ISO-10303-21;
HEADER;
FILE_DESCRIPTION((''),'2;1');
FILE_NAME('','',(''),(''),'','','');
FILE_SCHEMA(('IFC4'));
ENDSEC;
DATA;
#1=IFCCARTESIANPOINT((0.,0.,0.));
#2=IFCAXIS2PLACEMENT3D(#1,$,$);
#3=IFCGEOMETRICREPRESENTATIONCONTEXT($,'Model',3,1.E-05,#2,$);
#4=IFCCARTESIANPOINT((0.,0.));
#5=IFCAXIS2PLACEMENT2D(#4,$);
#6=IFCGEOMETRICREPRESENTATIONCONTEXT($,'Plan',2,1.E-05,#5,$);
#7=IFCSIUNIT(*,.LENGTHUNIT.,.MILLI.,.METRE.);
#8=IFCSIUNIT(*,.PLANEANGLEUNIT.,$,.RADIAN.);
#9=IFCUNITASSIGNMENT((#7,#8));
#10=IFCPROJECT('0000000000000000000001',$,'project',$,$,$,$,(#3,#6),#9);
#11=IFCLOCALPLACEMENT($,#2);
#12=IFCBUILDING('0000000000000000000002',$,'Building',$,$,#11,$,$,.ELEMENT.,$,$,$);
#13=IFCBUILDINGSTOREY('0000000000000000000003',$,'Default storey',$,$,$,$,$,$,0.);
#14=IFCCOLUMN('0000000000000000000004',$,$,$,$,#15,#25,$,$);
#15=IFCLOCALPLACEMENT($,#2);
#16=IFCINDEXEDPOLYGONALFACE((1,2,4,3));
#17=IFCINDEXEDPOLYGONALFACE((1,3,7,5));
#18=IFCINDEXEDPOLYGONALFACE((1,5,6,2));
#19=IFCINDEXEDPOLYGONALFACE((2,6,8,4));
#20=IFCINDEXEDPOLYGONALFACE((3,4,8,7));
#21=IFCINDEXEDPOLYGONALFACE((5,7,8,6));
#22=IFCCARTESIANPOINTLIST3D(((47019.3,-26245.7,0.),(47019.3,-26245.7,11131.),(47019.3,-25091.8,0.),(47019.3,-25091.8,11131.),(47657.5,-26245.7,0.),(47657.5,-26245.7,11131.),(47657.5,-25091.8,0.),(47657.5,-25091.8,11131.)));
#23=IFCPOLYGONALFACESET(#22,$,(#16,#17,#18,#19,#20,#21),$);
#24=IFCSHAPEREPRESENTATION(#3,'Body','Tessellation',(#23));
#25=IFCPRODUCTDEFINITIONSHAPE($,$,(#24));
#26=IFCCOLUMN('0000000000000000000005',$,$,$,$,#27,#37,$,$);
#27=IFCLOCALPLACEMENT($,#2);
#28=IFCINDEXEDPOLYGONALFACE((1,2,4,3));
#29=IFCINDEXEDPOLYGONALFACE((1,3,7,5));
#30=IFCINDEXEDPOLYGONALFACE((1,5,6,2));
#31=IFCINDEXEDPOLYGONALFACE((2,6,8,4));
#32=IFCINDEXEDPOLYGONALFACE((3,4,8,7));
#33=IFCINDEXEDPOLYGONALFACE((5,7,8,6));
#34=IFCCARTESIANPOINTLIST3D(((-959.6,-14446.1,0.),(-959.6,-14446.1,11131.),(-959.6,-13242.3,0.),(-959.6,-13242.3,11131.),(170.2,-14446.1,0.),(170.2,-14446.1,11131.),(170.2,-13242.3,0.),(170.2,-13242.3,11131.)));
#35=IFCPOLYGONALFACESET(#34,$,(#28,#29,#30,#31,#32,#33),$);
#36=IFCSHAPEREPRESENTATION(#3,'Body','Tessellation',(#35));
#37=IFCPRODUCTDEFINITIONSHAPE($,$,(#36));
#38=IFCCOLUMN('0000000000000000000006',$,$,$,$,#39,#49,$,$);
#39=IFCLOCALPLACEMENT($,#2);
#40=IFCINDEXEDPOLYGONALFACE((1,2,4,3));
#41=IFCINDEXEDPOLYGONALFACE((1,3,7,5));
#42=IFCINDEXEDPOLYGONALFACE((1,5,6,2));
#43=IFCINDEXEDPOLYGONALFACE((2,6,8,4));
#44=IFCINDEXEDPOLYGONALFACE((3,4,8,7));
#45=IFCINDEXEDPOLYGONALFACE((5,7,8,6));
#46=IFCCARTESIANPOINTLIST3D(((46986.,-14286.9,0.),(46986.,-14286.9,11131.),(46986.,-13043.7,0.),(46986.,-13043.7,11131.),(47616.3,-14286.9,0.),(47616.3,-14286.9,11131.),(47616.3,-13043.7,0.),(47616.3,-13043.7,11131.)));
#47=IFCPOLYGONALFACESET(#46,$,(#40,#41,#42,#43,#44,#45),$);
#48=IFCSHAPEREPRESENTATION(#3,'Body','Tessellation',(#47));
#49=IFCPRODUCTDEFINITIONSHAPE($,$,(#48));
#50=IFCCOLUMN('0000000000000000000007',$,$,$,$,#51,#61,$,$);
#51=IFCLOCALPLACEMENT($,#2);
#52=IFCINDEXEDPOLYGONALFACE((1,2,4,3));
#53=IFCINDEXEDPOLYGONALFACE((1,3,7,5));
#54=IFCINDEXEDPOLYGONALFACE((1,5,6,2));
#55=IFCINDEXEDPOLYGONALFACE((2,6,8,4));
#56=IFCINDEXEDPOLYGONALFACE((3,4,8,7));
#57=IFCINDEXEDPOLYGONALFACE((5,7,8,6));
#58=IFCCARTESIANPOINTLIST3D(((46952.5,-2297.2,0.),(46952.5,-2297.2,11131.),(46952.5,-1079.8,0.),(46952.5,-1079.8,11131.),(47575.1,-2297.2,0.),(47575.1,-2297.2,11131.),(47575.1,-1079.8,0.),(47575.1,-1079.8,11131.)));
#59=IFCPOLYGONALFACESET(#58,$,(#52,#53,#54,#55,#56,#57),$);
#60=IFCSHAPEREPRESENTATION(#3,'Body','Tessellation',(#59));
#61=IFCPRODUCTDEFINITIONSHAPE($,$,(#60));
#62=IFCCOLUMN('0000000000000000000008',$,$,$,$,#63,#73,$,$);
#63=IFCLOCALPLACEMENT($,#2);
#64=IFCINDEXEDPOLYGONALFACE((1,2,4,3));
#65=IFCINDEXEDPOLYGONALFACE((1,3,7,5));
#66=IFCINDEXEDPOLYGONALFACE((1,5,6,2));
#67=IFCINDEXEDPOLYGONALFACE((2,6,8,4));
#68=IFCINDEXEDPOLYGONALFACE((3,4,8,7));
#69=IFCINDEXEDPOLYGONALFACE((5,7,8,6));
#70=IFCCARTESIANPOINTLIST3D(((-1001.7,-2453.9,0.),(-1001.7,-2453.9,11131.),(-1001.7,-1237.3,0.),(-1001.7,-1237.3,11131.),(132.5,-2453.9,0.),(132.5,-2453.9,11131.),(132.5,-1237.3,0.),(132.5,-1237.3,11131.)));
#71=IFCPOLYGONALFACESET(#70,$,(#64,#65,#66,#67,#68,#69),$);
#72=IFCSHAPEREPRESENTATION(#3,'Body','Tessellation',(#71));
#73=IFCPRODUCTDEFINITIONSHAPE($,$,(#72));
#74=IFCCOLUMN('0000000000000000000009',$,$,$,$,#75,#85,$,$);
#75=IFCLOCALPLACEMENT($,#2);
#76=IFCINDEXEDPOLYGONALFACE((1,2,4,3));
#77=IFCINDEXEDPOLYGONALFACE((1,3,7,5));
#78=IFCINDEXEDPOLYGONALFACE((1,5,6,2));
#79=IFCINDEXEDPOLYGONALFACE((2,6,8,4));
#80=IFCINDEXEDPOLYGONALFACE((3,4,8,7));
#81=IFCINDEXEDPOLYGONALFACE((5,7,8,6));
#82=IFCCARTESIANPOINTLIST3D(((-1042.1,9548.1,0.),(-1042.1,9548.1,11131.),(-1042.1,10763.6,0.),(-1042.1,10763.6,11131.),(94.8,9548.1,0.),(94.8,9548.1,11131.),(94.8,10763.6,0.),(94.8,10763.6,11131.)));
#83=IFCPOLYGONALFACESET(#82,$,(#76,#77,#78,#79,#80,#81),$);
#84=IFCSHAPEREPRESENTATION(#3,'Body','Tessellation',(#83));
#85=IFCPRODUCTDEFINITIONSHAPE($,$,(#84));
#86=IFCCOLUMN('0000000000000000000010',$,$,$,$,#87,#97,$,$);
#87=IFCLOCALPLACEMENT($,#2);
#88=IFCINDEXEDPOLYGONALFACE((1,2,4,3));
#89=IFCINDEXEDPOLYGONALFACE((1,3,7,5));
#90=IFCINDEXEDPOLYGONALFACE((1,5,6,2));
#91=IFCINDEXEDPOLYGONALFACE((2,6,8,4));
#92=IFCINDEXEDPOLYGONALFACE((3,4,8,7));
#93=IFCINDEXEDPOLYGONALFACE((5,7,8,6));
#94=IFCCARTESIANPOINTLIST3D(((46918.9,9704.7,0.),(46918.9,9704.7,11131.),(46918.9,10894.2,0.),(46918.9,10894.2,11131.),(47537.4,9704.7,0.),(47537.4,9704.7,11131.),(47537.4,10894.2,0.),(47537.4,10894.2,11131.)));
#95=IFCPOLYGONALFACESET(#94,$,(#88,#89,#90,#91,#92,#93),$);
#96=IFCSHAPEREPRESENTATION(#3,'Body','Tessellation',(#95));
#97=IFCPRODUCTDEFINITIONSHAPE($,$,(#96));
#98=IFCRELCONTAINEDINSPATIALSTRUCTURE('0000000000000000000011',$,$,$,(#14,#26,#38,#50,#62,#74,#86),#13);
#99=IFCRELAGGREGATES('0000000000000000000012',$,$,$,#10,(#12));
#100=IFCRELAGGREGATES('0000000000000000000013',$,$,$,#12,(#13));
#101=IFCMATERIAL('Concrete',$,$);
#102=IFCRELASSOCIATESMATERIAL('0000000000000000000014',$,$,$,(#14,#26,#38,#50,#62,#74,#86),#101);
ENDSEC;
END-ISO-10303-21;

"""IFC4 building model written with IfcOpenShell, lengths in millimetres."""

from ifc_helpers import new_model, si_unit, frame, origin, origin_2d, place, context, project, spatial, rectangle, extrude, material, element, save


model = new_model("IFC4")

# Units and contexts
model_context = context("Model", 3, precision=1e-05, world=origin())
plan_context = context("Plan", 2, precision=1e-05, world=origin_2d())
ifc_project = project(units=[si_unit("LENGTHUNIT", "METRE", prefix="MILLI"), si_unit("PLANEANGLEUNIT", "RADIAN")], contexts=[model_context, plan_context])

# Building, storey
placement = place(None, origin())
building = spatial("IfcBuilding", under=ifc_project, at=placement, Name="Building", CompositionType="ELEMENT")
storey = spatial("IfcBuildingStorey", under=building, Name="Default storey", Elevation=0.0)

# Columns
ifc_material_1 = material(Name="Concrete")
element("IfcColumn", 1, at=placement, inside=storey, material=ifc_material_1, context=model_context, shape_type="SweptSolid", body=[
    extrude(rectangle(XDim=638.2, YDim=1153.9, at=origin_2d()), frame((47338.4, -25668.8, 0.0), z_axis=(0.0, 0.0, 1.0), x_axis=(1000.0, 0.0, 0.0)), (0.0, 0.0, 1.0), 11131.0),
])
element("IfcColumn", 2, at=placement, inside=storey, material=ifc_material_1, context=model_context, shape_type="SweptSolid", body=[
    extrude(rectangle(XDim=1129.8, YDim=1203.8, at=origin_2d()), frame((-394.7, -13844.2, 0.0), z_axis=(0.0, 0.0, 1.0), x_axis=(1000.0, 0.0, 0.0)), (0.0, 0.0, 1.0), 11131.0),
])
element("IfcColumn", 3, at=placement, inside=storey, material=ifc_material_1, context=model_context, shape_type="SweptSolid", body=[
    extrude(rectangle(XDim=630.3, YDim=1243.2, at=origin_2d()), frame((47301.2, -13665.3, 0.0), z_axis=(0.0, 0.0, 1.0), x_axis=(1000.0, 0.0, 0.0)), (0.0, 0.0, 1.0), 11131.0),
])
element("IfcColumn", 4, at=placement, inside=storey, material=ifc_material_1, context=model_context, shape_type="SweptSolid", body=[
    extrude(rectangle(XDim=622.6, YDim=1217.4, at=origin_2d()), frame((47263.8, -1688.5, 0.0), z_axis=(0.0, 0.0, 1.0), x_axis=(1000.0, 0.0, 0.0)), (0.0, 0.0, 1.0), 11131.0),
])
element("IfcColumn", 5, at=placement, inside=storey, material=ifc_material_1, context=model_context, shape_type="SweptSolid", body=[
    extrude(rectangle(XDim=1134.2, YDim=1216.6, at=origin_2d()), frame((-434.6, -1845.6, 0.0), z_axis=(0.0, 0.0, 1.0), x_axis=(1000.0, 0.0, 0.0)), (0.0, 0.0, 1.0), 11131.0),
])
element("IfcColumn", 6, at=placement, inside=storey, material=ifc_material_1, context=model_context, shape_type="SweptSolid", body=[
    extrude(rectangle(XDim=1136.9, YDim=1215.5, at=origin_2d()), frame((-473.6, 10155.9, 0.0), z_axis=(0.0, 0.0, 1.0), x_axis=(1000.0, 0.0, 0.0)), (0.0, 0.0, 1.0), 11131.0),
])
element("IfcColumn", 7, at=placement, inside=storey, material=ifc_material_1, context=model_context, shape_type="SweptSolid", body=[
    extrude(rectangle(XDim=618.5, YDim=1189.5, at=origin_2d()), frame((47228.2, 10299.5, 0.0), z_axis=(0.0, 0.0, 1.0), x_axis=(1000.0, 0.0, 0.0)), (0.0, 0.0, 1.0), 11131.0),
])

save(model, "model.ifc")
